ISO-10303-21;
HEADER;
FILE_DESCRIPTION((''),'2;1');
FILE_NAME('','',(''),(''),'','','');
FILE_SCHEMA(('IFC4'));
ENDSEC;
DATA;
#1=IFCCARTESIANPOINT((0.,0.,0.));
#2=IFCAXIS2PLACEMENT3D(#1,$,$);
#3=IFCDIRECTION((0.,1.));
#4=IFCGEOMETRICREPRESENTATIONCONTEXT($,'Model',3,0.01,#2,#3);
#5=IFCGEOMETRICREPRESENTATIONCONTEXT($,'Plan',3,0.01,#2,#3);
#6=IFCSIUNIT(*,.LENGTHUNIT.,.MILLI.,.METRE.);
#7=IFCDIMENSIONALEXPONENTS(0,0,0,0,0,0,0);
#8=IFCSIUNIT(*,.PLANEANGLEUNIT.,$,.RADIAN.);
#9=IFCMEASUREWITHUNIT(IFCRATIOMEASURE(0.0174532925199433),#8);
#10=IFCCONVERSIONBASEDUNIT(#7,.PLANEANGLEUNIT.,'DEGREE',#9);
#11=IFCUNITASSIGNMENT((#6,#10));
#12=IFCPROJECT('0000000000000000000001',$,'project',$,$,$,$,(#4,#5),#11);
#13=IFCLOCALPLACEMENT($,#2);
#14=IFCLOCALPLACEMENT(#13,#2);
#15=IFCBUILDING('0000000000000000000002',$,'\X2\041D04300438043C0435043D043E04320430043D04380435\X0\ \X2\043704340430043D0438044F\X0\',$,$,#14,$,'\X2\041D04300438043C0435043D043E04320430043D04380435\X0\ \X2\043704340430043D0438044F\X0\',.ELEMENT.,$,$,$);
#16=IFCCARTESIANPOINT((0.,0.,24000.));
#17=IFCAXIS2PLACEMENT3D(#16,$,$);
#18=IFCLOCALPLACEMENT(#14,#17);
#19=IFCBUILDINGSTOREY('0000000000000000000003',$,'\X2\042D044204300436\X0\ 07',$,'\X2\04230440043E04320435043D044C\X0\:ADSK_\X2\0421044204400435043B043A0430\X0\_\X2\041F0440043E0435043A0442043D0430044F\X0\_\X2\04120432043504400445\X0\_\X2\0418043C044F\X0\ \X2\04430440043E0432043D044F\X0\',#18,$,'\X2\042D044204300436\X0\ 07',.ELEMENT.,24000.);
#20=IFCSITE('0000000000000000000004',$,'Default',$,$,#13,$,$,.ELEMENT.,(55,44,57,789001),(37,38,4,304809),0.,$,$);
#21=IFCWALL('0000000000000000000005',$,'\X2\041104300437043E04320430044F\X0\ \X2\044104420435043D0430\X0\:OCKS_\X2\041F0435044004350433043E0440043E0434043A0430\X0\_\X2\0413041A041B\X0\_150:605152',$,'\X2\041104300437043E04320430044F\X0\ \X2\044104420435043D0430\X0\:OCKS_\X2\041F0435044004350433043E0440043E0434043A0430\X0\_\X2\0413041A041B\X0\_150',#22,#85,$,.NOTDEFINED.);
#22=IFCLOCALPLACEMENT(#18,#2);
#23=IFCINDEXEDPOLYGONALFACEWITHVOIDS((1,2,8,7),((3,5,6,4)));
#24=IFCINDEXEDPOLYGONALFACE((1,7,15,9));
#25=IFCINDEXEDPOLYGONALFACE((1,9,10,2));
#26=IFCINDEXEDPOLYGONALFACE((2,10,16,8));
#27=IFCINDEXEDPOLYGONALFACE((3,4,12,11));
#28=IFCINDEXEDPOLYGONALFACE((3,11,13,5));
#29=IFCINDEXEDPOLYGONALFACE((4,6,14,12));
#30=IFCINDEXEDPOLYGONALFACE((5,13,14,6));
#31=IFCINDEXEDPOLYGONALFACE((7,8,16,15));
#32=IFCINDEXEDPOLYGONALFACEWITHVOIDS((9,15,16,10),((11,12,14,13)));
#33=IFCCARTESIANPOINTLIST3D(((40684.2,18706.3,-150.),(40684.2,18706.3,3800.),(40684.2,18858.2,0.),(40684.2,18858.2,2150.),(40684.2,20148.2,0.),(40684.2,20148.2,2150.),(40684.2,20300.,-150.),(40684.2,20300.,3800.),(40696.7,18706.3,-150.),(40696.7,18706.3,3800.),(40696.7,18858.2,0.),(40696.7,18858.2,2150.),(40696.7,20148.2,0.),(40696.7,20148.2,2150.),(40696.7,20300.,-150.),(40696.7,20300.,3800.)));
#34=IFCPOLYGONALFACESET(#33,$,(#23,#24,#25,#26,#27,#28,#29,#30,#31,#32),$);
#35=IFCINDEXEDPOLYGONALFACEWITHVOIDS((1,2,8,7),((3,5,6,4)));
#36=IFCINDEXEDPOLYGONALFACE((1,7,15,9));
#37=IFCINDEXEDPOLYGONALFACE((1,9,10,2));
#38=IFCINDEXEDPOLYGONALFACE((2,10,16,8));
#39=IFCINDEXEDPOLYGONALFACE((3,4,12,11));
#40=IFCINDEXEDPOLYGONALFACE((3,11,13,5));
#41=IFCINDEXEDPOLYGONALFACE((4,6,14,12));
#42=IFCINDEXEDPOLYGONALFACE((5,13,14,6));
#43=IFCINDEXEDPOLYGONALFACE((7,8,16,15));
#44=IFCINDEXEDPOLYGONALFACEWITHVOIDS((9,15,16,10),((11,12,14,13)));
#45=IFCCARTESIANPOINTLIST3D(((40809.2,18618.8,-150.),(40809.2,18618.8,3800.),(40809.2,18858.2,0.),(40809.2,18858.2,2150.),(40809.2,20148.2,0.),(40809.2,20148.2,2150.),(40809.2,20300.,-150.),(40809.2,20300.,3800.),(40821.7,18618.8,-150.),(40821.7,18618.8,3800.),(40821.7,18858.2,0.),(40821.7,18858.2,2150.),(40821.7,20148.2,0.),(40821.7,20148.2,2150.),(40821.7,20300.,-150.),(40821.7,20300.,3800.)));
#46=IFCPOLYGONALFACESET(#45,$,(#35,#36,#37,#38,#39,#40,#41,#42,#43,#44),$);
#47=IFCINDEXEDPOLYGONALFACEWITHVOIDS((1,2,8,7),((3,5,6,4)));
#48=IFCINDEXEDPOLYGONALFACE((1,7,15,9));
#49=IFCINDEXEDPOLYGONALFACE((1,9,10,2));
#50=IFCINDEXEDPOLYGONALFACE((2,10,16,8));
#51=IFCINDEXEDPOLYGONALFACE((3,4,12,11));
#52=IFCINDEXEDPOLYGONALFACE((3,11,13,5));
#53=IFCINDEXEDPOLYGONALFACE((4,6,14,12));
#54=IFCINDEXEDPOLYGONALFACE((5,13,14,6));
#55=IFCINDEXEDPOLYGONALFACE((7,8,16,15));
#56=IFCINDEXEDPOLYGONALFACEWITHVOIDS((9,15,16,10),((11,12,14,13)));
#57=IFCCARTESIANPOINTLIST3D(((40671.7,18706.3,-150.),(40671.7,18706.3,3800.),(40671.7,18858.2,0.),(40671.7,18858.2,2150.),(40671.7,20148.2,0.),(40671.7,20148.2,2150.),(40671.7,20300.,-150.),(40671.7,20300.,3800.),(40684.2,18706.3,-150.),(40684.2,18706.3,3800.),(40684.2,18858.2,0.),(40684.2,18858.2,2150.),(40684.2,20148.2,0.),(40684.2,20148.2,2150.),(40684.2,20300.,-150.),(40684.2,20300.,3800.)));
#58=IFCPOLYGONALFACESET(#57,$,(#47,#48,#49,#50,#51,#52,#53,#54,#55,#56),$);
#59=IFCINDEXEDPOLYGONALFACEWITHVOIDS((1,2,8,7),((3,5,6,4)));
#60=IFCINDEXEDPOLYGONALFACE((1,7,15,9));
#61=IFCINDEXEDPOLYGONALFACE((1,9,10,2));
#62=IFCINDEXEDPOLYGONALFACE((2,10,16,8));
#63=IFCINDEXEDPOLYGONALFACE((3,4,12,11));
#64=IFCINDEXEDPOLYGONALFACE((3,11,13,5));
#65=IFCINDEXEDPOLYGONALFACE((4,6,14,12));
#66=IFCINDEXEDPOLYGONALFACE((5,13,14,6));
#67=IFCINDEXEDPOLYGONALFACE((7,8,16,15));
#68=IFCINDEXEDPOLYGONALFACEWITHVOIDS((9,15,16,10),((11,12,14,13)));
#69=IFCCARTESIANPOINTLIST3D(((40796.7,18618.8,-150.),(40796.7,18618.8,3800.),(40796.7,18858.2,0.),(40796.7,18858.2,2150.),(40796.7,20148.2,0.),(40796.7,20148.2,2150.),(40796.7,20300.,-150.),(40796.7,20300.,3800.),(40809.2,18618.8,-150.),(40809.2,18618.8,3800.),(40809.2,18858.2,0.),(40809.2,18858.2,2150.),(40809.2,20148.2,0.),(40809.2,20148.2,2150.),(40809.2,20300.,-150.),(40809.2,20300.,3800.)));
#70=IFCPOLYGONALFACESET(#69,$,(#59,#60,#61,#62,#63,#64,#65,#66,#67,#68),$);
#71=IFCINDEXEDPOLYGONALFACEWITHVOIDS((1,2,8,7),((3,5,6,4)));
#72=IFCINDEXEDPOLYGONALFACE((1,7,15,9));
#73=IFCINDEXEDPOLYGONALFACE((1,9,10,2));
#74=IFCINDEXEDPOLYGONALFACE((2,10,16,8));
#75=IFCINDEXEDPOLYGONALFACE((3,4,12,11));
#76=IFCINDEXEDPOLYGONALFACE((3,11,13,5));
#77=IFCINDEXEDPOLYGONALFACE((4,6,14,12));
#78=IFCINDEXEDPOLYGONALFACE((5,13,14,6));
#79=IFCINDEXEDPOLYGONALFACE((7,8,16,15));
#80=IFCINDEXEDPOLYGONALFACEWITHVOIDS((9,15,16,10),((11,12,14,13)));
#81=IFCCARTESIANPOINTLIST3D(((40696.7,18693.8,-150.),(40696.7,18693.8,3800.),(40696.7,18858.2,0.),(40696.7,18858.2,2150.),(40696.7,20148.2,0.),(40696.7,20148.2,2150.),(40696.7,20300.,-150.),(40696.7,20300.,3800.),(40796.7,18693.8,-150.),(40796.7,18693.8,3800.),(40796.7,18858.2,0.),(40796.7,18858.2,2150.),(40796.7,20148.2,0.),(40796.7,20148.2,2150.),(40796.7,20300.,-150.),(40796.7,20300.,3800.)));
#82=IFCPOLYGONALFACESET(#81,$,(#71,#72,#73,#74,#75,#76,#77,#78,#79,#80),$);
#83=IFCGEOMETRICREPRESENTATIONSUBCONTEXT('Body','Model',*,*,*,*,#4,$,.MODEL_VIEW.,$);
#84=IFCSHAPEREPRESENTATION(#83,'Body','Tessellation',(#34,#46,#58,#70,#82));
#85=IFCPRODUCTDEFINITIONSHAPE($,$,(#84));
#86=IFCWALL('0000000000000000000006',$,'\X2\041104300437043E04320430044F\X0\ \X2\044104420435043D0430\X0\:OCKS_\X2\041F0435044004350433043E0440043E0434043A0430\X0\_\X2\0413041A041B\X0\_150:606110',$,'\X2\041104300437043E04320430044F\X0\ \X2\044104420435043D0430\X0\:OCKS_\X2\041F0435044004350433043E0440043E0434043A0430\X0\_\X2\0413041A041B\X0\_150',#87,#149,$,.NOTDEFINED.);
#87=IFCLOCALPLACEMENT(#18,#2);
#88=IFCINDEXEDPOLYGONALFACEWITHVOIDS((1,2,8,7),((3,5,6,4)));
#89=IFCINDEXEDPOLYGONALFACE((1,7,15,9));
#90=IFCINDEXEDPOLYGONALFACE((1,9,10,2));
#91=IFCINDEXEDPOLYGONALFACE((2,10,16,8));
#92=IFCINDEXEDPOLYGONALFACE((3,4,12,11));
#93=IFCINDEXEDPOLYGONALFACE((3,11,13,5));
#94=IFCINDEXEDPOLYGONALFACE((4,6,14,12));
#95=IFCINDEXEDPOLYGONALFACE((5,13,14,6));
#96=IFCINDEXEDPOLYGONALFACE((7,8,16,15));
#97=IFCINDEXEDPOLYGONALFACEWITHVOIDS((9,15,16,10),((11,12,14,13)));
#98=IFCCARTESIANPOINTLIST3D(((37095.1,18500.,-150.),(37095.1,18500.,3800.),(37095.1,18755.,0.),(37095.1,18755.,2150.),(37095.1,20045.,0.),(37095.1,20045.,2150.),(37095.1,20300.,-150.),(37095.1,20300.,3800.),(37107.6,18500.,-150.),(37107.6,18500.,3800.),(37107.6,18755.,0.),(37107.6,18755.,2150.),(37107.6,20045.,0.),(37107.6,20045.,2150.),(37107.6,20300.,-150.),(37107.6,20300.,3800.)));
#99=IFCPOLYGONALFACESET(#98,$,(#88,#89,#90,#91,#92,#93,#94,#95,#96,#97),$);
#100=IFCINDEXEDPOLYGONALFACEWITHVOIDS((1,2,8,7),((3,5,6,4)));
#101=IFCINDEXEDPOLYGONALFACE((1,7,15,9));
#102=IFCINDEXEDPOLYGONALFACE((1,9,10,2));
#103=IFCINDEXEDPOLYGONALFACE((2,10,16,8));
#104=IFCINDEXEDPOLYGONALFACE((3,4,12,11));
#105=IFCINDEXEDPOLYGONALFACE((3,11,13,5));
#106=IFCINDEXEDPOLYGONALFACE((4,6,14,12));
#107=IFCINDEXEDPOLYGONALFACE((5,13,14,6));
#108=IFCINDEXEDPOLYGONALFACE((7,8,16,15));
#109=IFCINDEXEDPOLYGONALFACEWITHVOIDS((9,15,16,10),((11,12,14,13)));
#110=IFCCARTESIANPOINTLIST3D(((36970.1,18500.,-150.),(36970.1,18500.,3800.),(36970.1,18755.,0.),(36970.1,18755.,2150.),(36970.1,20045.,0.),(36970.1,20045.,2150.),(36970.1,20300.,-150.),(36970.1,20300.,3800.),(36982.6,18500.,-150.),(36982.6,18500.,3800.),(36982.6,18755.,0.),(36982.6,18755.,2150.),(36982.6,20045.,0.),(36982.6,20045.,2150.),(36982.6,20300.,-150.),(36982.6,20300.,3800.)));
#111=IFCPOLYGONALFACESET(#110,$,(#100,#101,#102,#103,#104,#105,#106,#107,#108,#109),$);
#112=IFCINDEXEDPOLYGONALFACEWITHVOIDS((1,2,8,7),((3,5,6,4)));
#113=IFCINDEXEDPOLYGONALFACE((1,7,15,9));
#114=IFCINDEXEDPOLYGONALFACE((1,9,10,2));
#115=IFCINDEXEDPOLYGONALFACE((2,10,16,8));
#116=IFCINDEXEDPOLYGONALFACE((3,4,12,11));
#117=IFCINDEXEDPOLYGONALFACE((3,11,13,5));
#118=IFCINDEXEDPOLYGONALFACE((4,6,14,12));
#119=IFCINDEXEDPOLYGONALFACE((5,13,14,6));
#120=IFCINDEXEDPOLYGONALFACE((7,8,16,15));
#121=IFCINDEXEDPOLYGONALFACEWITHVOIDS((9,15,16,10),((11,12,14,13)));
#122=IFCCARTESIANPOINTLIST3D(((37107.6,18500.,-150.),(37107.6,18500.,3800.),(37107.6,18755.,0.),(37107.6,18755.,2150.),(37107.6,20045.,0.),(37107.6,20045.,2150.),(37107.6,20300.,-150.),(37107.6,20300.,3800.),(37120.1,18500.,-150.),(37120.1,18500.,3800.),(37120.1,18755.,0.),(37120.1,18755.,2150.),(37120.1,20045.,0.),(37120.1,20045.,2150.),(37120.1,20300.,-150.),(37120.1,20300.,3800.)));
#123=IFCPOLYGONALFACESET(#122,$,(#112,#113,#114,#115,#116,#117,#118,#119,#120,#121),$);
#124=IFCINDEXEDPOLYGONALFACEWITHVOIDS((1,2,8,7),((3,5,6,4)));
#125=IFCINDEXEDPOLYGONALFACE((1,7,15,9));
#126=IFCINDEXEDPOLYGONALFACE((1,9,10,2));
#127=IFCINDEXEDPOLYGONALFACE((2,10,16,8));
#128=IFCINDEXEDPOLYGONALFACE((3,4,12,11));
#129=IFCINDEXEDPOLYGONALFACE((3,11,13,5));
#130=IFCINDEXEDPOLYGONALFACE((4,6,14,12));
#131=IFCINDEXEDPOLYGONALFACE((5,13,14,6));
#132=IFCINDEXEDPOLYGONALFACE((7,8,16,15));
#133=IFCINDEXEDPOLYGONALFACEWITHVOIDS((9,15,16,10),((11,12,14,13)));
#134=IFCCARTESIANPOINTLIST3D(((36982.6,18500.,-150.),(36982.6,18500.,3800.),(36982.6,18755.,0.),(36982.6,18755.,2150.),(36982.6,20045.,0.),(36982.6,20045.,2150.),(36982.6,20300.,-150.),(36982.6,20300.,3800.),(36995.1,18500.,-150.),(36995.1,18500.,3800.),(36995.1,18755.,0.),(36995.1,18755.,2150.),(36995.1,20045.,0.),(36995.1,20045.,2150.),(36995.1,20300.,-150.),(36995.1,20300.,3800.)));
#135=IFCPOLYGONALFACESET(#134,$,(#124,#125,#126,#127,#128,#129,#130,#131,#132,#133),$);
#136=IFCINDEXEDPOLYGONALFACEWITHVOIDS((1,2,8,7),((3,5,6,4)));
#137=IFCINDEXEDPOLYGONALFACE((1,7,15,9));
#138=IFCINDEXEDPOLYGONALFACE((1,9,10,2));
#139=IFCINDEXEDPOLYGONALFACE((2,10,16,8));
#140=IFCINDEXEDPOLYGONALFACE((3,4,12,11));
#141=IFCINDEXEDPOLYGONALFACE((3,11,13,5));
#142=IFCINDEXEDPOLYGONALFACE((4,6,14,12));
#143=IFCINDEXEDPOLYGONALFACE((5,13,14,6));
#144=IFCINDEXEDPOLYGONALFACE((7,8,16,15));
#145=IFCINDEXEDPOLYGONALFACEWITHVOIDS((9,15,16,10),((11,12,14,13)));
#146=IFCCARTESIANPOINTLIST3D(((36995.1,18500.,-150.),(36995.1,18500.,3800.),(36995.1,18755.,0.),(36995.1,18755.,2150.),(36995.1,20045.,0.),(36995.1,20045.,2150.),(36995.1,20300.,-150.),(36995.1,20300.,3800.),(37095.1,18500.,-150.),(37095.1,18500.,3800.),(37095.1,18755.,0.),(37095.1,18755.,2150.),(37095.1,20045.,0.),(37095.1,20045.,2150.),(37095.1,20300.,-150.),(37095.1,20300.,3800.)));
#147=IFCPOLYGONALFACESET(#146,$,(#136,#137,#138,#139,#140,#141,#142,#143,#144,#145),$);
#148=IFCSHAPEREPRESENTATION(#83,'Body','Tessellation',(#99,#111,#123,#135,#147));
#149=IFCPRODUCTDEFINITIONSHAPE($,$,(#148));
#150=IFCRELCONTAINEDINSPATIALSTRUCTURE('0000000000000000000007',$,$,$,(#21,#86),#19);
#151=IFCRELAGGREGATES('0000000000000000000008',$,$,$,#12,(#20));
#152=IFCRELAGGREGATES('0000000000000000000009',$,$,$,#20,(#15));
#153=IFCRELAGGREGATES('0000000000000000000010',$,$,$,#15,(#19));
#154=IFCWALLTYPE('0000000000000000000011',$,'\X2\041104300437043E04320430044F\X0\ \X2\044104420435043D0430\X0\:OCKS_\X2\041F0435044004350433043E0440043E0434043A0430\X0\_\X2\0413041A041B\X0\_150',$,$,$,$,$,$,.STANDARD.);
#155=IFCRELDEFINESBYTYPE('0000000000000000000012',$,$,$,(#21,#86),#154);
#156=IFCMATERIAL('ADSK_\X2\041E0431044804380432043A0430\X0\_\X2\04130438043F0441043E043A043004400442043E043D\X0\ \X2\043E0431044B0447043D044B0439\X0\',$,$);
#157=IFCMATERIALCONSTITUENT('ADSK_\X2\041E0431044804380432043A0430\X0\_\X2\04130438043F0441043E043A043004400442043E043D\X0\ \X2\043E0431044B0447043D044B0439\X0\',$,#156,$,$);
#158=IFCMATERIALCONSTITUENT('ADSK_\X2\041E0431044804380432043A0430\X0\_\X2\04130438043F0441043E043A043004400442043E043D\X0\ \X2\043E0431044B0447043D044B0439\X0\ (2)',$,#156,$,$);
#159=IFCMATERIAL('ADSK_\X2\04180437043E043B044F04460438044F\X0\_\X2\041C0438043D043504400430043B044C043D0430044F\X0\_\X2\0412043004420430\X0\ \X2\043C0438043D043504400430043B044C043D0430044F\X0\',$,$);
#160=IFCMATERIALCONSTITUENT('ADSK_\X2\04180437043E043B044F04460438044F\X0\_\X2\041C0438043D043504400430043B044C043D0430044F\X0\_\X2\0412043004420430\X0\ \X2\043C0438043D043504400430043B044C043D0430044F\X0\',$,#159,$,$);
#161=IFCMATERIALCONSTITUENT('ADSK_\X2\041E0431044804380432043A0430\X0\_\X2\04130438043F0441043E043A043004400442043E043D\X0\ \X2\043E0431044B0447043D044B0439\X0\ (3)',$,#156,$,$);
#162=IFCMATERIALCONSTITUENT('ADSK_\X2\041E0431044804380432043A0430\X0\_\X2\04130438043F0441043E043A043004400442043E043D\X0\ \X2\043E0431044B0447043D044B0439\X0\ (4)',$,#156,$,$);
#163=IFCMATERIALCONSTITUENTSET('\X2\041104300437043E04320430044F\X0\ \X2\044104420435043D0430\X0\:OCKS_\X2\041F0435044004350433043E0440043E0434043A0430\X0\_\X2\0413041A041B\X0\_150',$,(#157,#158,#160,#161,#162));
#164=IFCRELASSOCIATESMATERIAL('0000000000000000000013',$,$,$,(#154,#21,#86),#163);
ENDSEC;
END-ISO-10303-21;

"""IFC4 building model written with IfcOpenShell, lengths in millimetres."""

from ifc_helpers import new_model, entity, si_unit, converted_unit, direction, frame, origin, place, context, subcontext, project, spatial, indexed_curve, outline, extrude, material, constituent, constituent_set, type_object, element, save


model = new_model("IFC4")

# Units and contexts
model_context = context("Model", 3, precision=0.01, world=origin(), true_north=direction((0.0, 1.0)))
plan_context = context("Plan", 3, precision=0.01, world=origin(), true_north=direction((0.0, 1.0)))
body_context = subcontext(model_context, "Body", "Model", "MODEL_VIEW")
ifc_project = project(units=[si_unit("LENGTHUNIT", "METRE", prefix="MILLI"), converted_unit("PLANEANGLEUNIT", "DEGREE", entity("IfcRatioMeasure", 0.0174532925199433), si_unit("PLANEANGLEUNIT", "RADIAN"), dimensions=[0, 0, 0, 0, 0, 0, 0])], contexts=[model_context, plan_context])

# Site, building, storey
site_placement = place(None, frame((0.0, 0.0, 0.0)))
site = spatial("IfcSite", under=ifc_project, at=site_placement, Name="Default", CompositionType="ELEMENT", RefLatitude=(55, 44, 57, 789001), RefLongitude=(37, 38, 4, 304809), RefElevation=0.0)
building_placement = place(site_placement, origin())
building = spatial("IfcBuilding", under=site, at=building_placement, Name="Наименование здания", LongName="Наименование здания", CompositionType="ELEMENT")
storey_placement = place(building_placement, frame((0.0, 0.0, 24000.0)))
storey = spatial("IfcBuildingStorey", under=building, at=storey_placement, Name="Этаж 07", ObjectType="Уровень:ADSK_Стрелка_Проектная_Вверх_Имя уровня", LongName="Этаж 07", CompositionType="ELEMENT", Elevation=24000.0)

# Walls, openings
ifc_material_1 = material(Name="ADSK_Обшивка_Гипсокартон обычный")
ifc_constituent_1 = constituent(ifc_material_1, Name="ADSK_Обшивка_Гипсокартон обычный")
ifc_constituent_2 = constituent(ifc_material_1, Name="ADSK_Обшивка_Гипсокартон обычный (2)")
ifc_material_2 = material(Name="ADSK_Изоляция_Минеральная_Вата минеральная")
ifc_constituent_3 = constituent(ifc_material_2, Name="ADSK_Изоляция_Минеральная_Вата минеральная")
ifc_constituent_4 = constituent(ifc_material_1, Name="ADSK_Обшивка_Гипсокартон обычный (3)")
ifc_constituent_5 = constituent(ifc_material_1, Name="ADSK_Обшивка_Гипсокартон обычный (4)")
ifc_constituent_set_1 = constituent_set(constituents=[ifc_constituent_1, ifc_constituent_2, ifc_constituent_3, ifc_constituent_4, ifc_constituent_5], Name="Базовая стена:OCKS_Перегородка_ГКЛ_150")
wall_type_1 = type_object("IfcWallType", Name="Базовая стена:OCKS_Перегородка_ГКЛ_150", PredefinedType="STANDARD", material=ifc_constituent_set_1)
wall_1_placement = place(storey_placement, frame((40746.7, 20300.0, -150.0), z_axis=(0.0, 0.0, 1.0), x_axis=(0.0, -1.0, 0.0)))
wall_1 = element("IfcWall", 1, at=wall_1_placement, inside=storey, type_object=wall_type_1, material=ifc_constituent_set_1, Name="Базовая стена:OCKS_Перегородка_ГКЛ_150:605152", ObjectType="Базовая стена:OCKS_Перегородка_ГКЛ_150", PredefinedType="NOTDEFINED", context=body_context, shape_type="SweptSolid", body=[
    extrude(outline(indexed_curve([(-1975.0, -796.8), (1975.0, -796.8), (1975.0, 796.8), (-1975.0, 796.8), (-1975.0, -796.8)], self_intersect=False), holes=[indexed_curve([(325.0, 645.0), (325.0, -645.0), (-1825.0, -645.0), (-1825.0, 645.0), (325.0, 645.0)], self_intersect=False)]), frame((796.8, -62.5, 1975.0), z_axis=(0.0, 1.0, 0.0), x_axis=(0.0, 0.0, 1.0)), (0.0, 0.0, 1.0), 12.5),
    extrude(outline(indexed_curve([(-1975.0, -840.6), (1975.0, -840.6), (1975.0, 840.6), (-1975.0, 840.6), (-1975.0, -840.6)], self_intersect=False), holes=[indexed_curve([(325.0, 601.2), (325.0, -688.8), (-1825.0, -688.8), (-1825.0, 601.2), (325.0, 601.2)], self_intersect=False)]), frame((840.6, 62.5, 1975.0), z_axis=(0.0, 1.0, 0.0), x_axis=(0.0, 0.0, 1.0)), (0.0, 0.0, 1.0), 12.5),
    extrude(outline(indexed_curve([(-1975.0, -796.8), (1975.0, -796.8), (1975.0, 796.8), (-1975.0, 796.8), (-1975.0, -796.8)], self_intersect=False), holes=[indexed_curve([(325.0, 645.0), (325.0, -645.0), (-1825.0, -645.0), (-1825.0, 645.0), (325.0, 645.0)], self_intersect=False)]), frame((796.8, -75.0, 1975.0), z_axis=(0.0, 1.0, 0.0), x_axis=(0.0, 0.0, 1.0)), (0.0, 0.0, 1.0), 12.5),
    extrude(outline(indexed_curve([(-1975.0, -840.6), (1975.0, -840.6), (1975.0, 840.6), (-1975.0, 840.6), (-1975.0, -840.6)], self_intersect=False), holes=[indexed_curve([(325.0, 601.2), (325.0, -688.8), (-1825.0, -688.8), (-1825.0, 601.2), (325.0, 601.2)], self_intersect=False)]), frame((840.6, 50.0, 1975.0), z_axis=(0.0, 1.0, 0.0), x_axis=(0.0, 0.0, 1.0)), (0.0, 0.0, 1.0), 12.5),
    extrude(outline(indexed_curve([(-1975.0, -803.1), (1975.0, -803.1), (1975.0, 803.1), (-1975.0, 803.1), (-1975.0, -803.1)], self_intersect=False), holes=[indexed_curve([(325.0, 638.7), (325.0, -651.3), (-1825.0, -651.3), (-1825.0, 638.7), (325.0, 638.7)], self_intersect=False)]), frame((803.1, -50.0, 1975.0), z_axis=(0.0, 1.0, 0.0), x_axis=(0.0, 0.0, 1.0)), (0.0, 0.0, 1.0), 100.0),
])
opening_1_placement = place(wall_1_placement, frame((20300.0, -40746.7, 150.0), z_axis=(0.0, 0.0, 1.0), x_axis=(0.0, 1.0, 0.0)))
element("IfcOpeningElement", 2, at=opening_1_placement, cuts=wall_1, PredefinedType="OPENING", context=body_context, shape_type="SweptSolid", body=[
    extrude(outline(indexed_curve([(-1075.0, -645.0), (1075.0, -645.0), (1075.0, 645.0), (-1075.0, 645.0), (-1075.0, -645.0)], self_intersect=False)), frame((39846.7, 19503.2, 1075.0), z_axis=(1.0, 0.0, 0.0), x_axis=(0.0, 0.0, -1.0)), (0.0, 0.0, 1.0), 1800.0),
])
wall_2_placement = place(storey_placement, frame((37045.1, 18500.0, -150.0), z_axis=(0.0, 0.0, 1.0), x_axis=(0.0, 1.0, 0.0)))
wall_2 = element("IfcWall", 3, at=wall_2_placement, inside=storey, type_object=wall_type_1, material=ifc_constituent_set_1, Name="Базовая стена:OCKS_Перегородка_ГКЛ_150:606110", ObjectType="Базовая стена:OCKS_Перегородка_ГКЛ_150", PredefinedType="NOTDEFINED", context=body_context, shape_type="SweptSolid", body=[
    extrude(outline(indexed_curve([(-1975.0, -900.0), (1975.0, -900.0), (1975.0, 900.0), (-1975.0, 900.0), (-1975.0, -900.0)], self_intersect=False), holes=[indexed_curve([(325.0, 645.0), (325.0, -645.0), (-1825.0, -645.0), (-1825.0, 645.0), (325.0, 645.0)], self_intersect=False)]), frame((900.0, -50.0, 1975.0), z_axis=(0.0, -1.0, 0.0), x_axis=(0.0, 0.0, 1.0)), (0.0, 0.0, 1.0), 12.5),
    extrude(outline(indexed_curve([(-1975.0, -900.0), (1975.0, -900.0), (1975.0, 900.0), (-1975.0, 900.0), (-1975.0, -900.0)], self_intersect=False), holes=[indexed_curve([(325.0, 645.0), (325.0, -645.0), (-1825.0, -645.0), (-1825.0, 645.0), (325.0, 645.0)], self_intersect=False)]), frame((900.0, 75.0, 1975.0), z_axis=(0.0, -1.0, 0.0), x_axis=(0.0, 0.0, 1.0)), (0.0, 0.0, 1.0), 12.5),
    extrude(outline(indexed_curve([(-1975.0, -900.0), (1975.0, -900.0), (1975.0, 900.0), (-1975.0, 900.0), (-1975.0, -900.0)], self_intersect=False), holes=[indexed_curve([(325.0, 645.0), (325.0, -645.0), (-1825.0, -645.0), (-1825.0, 645.0), (325.0, 645.0)], self_intersect=False)]), frame((900.0, -62.5, 1975.0), z_axis=(0.0, -1.0, 0.0), x_axis=(0.0, 0.0, 1.0)), (0.0, 0.0, 1.0), 12.5),
    extrude(outline(indexed_curve([(-1975.0, -900.0), (1975.0, -900.0), (1975.0, 900.0), (-1975.0, 900.0), (-1975.0, -900.0)], self_intersect=False), holes=[indexed_curve([(325.0, 645.0), (325.0, -645.0), (-1825.0, -645.0), (-1825.0, 645.0), (325.0, 645.0)], self_intersect=False)]), frame((900.0, 62.5, 1975.0), z_axis=(0.0, -1.0, 0.0), x_axis=(0.0, 0.0, 1.0)), (0.0, 0.0, 1.0), 12.5),
    extrude(outline(indexed_curve([(-1975.0, -900.0), (1975.0, -900.0), (1975.0, 900.0), (-1975.0, 900.0), (-1975.0, -900.0)], self_intersect=False), holes=[indexed_curve([(325.0, 645.0), (325.0, -645.0), (-1825.0, -645.0), (-1825.0, 645.0), (325.0, 645.0)], self_intersect=False)]), frame((900.0, 50.0, 1975.0), z_axis=(0.0, -1.0, 0.0), x_axis=(0.0, 0.0, 1.0)), (0.0, 0.0, 1.0), 100.0),
])
opening_2_placement = place(wall_2_placement, frame((-18500.0, 37045.1, 150.0), z_axis=(0.0, 0.0, 1.0), x_axis=(0.0, -1.0, 0.0)))
element("IfcOpeningElement", 4, at=opening_2_placement, cuts=wall_2, PredefinedType="OPENING", context=body_context, shape_type="SweptSolid", body=[
    extrude(outline(indexed_curve([(-645.0, -1075.0), (645.0, -1075.0), (645.0, 1075.0), (-645.0, 1075.0), (-645.0, -1075.0)], self_intersect=False)), frame((37945.1, 19400.0, 1075.0), z_axis=(-1.0, 0.0, 0.0), x_axis=(0.0, 1.0, 0.0)), (0.0, 0.0, 1.0), 1800.0),
])

save(model, "model.ifc")
